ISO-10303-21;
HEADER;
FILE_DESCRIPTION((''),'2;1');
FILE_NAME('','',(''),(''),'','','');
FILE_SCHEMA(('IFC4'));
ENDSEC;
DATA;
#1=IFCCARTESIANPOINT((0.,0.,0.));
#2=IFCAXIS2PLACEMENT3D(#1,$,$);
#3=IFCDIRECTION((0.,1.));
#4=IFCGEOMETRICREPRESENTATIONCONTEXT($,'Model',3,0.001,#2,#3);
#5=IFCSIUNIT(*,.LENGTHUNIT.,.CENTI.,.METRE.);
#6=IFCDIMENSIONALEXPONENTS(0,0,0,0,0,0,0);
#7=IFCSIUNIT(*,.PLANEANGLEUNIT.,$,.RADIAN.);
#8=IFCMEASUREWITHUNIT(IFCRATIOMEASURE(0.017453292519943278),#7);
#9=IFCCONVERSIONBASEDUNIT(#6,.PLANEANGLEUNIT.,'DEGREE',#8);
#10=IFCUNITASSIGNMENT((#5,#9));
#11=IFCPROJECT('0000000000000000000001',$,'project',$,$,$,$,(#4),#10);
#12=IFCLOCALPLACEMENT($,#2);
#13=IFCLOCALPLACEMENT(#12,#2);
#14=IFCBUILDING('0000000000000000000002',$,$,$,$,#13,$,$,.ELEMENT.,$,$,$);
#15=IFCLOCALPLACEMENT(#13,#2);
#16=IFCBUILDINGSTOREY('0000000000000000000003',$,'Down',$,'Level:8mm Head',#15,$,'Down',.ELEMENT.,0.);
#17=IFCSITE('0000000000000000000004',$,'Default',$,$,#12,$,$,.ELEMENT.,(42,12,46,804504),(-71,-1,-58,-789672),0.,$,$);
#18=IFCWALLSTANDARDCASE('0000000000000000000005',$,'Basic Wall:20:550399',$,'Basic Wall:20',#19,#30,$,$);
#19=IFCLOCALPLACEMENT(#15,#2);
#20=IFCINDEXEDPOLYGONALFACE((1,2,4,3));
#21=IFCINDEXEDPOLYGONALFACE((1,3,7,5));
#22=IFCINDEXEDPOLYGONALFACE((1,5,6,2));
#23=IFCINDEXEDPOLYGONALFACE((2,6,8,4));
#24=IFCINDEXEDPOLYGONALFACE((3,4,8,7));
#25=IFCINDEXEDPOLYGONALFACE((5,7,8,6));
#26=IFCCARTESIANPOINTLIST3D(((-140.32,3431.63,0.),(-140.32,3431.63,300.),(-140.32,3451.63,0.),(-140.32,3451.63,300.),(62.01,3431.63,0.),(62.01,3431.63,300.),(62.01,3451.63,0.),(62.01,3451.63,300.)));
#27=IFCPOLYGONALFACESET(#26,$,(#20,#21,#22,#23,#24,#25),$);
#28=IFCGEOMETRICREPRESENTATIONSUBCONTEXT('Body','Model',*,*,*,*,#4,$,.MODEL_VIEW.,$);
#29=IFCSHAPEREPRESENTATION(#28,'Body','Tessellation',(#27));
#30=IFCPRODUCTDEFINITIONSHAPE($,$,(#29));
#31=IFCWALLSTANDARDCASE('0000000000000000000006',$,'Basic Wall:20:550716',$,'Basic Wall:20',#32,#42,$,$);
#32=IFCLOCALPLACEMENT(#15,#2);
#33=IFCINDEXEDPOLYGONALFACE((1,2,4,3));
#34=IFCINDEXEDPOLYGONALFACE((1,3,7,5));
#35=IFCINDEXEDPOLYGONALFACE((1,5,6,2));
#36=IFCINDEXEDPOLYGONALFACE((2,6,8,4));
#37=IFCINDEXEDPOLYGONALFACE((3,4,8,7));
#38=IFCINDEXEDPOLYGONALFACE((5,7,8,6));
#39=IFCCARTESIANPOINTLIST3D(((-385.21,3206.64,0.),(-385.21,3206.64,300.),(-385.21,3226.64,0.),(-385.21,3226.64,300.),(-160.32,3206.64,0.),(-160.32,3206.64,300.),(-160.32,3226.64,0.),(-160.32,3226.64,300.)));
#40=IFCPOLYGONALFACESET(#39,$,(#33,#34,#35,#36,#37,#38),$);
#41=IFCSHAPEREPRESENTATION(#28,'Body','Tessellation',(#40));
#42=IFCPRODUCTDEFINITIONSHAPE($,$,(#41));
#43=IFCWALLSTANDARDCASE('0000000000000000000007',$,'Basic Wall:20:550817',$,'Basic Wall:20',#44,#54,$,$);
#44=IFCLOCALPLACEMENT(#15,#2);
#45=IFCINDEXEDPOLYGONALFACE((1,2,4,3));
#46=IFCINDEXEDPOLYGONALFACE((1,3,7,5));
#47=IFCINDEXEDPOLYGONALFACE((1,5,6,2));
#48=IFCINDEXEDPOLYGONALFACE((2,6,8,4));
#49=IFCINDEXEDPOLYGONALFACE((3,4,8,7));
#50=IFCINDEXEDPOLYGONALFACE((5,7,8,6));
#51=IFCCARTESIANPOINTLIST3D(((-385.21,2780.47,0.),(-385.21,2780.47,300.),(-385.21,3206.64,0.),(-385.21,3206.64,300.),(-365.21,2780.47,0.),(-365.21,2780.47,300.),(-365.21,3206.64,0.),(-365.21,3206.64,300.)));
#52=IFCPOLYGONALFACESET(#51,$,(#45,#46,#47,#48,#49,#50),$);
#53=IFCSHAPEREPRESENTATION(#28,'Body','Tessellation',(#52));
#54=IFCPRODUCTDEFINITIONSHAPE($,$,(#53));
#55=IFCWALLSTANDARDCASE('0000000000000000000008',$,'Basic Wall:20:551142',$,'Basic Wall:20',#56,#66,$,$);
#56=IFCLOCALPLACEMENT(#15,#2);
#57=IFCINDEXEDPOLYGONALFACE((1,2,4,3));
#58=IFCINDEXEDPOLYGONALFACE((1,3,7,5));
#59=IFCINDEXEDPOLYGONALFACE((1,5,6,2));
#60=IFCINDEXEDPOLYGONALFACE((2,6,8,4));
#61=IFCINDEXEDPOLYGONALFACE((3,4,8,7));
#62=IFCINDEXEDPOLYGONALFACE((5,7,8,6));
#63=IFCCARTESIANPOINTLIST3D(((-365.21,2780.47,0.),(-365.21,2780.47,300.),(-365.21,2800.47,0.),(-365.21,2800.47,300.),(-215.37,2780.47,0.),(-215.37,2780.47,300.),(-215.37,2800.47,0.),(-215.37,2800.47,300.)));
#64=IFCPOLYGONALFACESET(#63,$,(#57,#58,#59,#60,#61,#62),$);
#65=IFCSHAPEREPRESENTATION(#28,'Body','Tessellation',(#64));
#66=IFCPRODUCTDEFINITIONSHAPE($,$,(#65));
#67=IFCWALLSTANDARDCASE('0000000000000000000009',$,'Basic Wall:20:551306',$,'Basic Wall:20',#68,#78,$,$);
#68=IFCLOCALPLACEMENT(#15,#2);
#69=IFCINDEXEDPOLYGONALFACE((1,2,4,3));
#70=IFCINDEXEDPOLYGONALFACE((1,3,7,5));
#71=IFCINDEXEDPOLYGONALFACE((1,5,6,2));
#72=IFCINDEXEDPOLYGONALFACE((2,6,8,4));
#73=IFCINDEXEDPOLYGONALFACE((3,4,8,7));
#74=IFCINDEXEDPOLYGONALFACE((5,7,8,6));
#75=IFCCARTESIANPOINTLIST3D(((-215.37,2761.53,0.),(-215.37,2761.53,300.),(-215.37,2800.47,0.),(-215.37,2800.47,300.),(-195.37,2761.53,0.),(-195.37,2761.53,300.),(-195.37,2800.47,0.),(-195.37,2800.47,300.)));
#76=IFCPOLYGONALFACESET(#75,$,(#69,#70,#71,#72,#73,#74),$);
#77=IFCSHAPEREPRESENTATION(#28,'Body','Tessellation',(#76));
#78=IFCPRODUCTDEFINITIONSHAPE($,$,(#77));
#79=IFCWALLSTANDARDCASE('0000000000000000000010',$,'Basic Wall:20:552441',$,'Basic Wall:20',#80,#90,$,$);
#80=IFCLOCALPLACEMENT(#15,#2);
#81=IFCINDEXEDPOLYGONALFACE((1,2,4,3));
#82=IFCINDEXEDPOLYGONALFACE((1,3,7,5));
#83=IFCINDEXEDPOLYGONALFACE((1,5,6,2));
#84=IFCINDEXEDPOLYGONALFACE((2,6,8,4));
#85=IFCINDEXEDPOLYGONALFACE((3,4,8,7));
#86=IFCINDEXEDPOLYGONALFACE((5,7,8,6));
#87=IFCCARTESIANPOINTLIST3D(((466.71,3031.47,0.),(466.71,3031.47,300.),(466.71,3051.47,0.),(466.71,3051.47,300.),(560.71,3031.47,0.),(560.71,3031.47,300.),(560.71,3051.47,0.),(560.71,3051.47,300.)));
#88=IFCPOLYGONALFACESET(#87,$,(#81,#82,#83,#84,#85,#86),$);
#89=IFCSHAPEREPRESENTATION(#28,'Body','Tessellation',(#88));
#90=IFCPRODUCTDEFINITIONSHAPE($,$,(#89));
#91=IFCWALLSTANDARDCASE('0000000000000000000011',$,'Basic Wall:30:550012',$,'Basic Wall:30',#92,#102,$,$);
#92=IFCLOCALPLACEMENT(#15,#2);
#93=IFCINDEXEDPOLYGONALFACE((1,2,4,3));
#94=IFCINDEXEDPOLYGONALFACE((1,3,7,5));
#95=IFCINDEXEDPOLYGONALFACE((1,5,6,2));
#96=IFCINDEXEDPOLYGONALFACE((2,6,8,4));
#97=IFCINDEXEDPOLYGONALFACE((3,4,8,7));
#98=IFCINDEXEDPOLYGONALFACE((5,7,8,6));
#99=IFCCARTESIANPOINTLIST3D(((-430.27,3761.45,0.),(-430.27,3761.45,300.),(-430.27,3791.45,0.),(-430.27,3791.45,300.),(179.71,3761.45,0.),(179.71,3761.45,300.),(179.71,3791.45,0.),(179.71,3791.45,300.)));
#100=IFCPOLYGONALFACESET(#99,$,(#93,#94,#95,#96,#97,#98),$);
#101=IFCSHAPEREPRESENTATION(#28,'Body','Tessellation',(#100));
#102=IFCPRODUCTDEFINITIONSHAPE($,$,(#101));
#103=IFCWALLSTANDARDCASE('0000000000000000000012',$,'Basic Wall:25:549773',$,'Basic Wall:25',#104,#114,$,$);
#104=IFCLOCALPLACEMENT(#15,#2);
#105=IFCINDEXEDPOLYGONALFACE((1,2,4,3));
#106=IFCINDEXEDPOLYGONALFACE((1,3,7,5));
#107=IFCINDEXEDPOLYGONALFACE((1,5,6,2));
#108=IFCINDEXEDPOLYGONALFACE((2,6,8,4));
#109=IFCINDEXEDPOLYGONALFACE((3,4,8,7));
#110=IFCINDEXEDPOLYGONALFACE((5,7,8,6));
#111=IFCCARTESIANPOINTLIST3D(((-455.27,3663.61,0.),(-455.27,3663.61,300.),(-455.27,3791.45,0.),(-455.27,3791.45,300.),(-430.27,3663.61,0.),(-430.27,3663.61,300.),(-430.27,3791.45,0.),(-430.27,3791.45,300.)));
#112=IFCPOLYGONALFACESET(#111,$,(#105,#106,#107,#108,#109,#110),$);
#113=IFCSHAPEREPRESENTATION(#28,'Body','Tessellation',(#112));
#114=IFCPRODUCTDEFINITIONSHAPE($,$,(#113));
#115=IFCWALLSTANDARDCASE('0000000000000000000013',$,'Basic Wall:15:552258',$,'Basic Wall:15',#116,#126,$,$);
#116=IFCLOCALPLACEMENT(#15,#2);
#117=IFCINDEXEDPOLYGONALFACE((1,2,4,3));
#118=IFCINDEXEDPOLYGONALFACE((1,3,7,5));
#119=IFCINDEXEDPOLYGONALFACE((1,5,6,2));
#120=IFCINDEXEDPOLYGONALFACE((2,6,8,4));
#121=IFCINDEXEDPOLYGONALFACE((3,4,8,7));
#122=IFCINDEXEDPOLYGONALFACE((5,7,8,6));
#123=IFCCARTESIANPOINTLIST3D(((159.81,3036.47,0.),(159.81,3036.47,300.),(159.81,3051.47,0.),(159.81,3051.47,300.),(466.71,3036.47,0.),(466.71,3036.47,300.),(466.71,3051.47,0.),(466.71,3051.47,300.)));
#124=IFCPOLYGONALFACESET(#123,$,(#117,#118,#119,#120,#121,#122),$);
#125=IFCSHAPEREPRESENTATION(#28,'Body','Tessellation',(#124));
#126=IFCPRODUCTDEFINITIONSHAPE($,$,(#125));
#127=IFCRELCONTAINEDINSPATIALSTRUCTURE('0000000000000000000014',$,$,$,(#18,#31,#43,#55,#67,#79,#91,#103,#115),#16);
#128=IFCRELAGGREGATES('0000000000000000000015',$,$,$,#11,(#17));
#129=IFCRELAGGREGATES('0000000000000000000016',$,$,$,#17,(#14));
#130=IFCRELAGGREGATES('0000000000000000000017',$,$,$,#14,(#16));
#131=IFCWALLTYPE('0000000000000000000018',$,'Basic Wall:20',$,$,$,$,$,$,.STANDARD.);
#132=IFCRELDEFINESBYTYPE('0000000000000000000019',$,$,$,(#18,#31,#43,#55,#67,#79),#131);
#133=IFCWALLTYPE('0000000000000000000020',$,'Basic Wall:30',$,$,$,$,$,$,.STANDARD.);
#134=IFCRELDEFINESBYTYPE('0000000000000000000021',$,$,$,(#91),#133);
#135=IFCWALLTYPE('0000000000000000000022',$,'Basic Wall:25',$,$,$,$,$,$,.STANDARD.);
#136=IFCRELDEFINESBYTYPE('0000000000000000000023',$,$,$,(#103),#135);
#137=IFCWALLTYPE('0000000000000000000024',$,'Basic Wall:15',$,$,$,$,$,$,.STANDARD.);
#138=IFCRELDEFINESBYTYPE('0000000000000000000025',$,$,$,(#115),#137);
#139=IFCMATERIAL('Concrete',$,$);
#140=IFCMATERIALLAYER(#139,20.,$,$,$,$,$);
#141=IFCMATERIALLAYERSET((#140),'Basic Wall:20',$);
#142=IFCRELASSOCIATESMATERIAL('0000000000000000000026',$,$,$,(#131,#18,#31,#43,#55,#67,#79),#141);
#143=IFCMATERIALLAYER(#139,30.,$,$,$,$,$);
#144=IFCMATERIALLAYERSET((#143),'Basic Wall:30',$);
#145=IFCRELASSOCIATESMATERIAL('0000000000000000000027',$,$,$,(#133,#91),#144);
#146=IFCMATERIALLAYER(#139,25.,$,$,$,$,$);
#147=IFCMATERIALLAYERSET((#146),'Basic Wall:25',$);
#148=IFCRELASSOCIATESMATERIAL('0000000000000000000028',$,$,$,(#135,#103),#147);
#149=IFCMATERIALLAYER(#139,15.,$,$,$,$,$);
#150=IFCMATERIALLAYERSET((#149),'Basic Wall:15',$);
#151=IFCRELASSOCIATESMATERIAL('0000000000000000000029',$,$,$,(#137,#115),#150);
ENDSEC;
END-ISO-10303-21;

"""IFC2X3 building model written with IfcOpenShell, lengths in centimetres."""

from ifc_helpers import new_model, entity, si_unit, converted_unit, direction, frame, frame_2d, origin, place, context, subcontext, project, spatial, rectangle, extrude, material, layer, layer_set, layer_usage, type_object, element, save


model = new_model("IFC2X3")

# Units and contexts
model_context = context("Model", 3, precision=0.001, world=origin(), true_north=direction((0.0, 1.0)))
body_context = subcontext(model_context, "Body", "Model", "MODEL_VIEW")
ifc_project = project(units=[si_unit("LENGTHUNIT", "METRE", prefix="CENTI"), converted_unit("PLANEANGLEUNIT", "DEGREE", entity("IfcRatioMeasure", 0.017453292519943278), si_unit("PLANEANGLEUNIT", "RADIAN"), dimensions=[0, 0, 0, 0, 0, 0, 0])], contexts=[model_context])

# Site, building, storey
site_placement = place(None, origin())
site = spatial("IfcSite", under=ifc_project, at=site_placement, Name="Default", CompositionType="ELEMENT", RefLatitude=(42, 12, 46, 804504), RefLongitude=(-71, -1, -58, -789672), RefElevation=0.0)
building_placement = place(site_placement, origin())
building = spatial("IfcBuilding", under=site, at=building_placement, CompositionType="ELEMENT")
storey_placement = place(building_placement, origin())
storey = spatial("IfcBuildingStorey", under=building, at=storey_placement, Name="Down", ObjectType="Level:8mm Head", LongName="Down", CompositionType="ELEMENT", Elevation=0.0)

# Walls
ifc_material = material(Name="Concrete")
ifc_layer_1 = layer(ifc_material, 20.0)
ifc_layer_set_1 = layer_set([ifc_layer_1], Name="Basic Wall:20")
wall_type_1 = type_object("IfcWallType", Name="Basic Wall:20", PredefinedType="STANDARD", material=ifc_layer_set_1)
ifc_layer_usage_1 = layer_usage(ifc_layer_set_1, "AXIS2", "NEGATIVE", 10.0)
wall_1_placement = place(storey_placement, frame((62.01, 3441.63, 0.0), z_axis=(0.0, 0.0, 1.0), x_axis=(-1.0, 0.0, 0.0)))
element("IfcWallStandardCase", 1, at=wall_1_placement, inside=storey, type_object=wall_type_1, material=ifc_layer_usage_1, Name="Basic Wall:20:550399", ObjectType="Basic Wall:20", context=body_context, shape_type="SweptSolid", body=[
    extrude(rectangle(XDim=202.33, YDim=20.0, at=frame_2d((101.17, 0.0), x_axis=(-1.0, 0.0))), origin(), (0.0, 0.0, 1.0), 300.0),
])
ifc_layer_usage_2 = layer_usage(ifc_layer_set_1, "AXIS2", "NEGATIVE", 10.0)
wall_2_placement = place(storey_placement, frame((-160.32, 3216.64, 0.0), z_axis=(0.0, 0.0, 1.0), x_axis=(-1.0, 0.0, 0.0)))
element("IfcWallStandardCase", 2, at=wall_2_placement, inside=storey, type_object=wall_type_1, material=ifc_layer_usage_2, Name="Basic Wall:20:550716", ObjectType="Basic Wall:20", context=body_context, shape_type="SweptSolid", body=[
    extrude(rectangle(XDim=224.89, YDim=20.0, at=frame_2d((112.44, 0.0), x_axis=(-1.0, 0.0))), origin(), (0.0, 0.0, 1.0), 300.0),
])
ifc_layer_usage_3 = layer_usage(ifc_layer_set_1, "AXIS2", "POSITIVE", -10.0)
wall_3_placement = place(storey_placement, frame((-375.21, 3206.64, 0.0), z_axis=(0.0, 0.0, 1.0), x_axis=(0.0, -1.0, 0.0)))
element("IfcWallStandardCase", 3, at=wall_3_placement, inside=storey, type_object=wall_type_1, material=ifc_layer_usage_3, Name="Basic Wall:20:550817", ObjectType="Basic Wall:20", context=body_context, shape_type="SweptSolid", body=[
    extrude(rectangle(XDim=426.17, YDim=20.0, at=frame_2d((213.09, 0.0), x_axis=(-1.0, 0.0))), origin(), (0.0, 0.0, 1.0), 300.0),
])
ifc_layer_usage_4 = layer_usage(ifc_layer_set_1, "AXIS2", "POSITIVE", -10.0)
wall_4_placement = place(storey_placement, frame((-365.21, 2790.47, 0.0)))
element("IfcWallStandardCase", 4, at=wall_4_placement, inside=storey, type_object=wall_type_1, material=ifc_layer_usage_4, Name="Basic Wall:20:551142", ObjectType="Basic Wall:20", context=body_context, shape_type="SweptSolid", body=[
    extrude(rectangle(XDim=149.84, YDim=20.0, at=frame_2d((74.92, 0.0), x_axis=(-1.0, 0.0))), origin(), (0.0, 0.0, 1.0), 300.0),
])
ifc_layer_usage_5 = layer_usage(ifc_layer_set_1, "AXIS2", "NEGATIVE", 10.0)
wall_5_placement = place(storey_placement, frame((-205.37, 2800.47, 0.0), z_axis=(0.0, 0.0, 1.0), x_axis=(0.0, -1.0, 0.0)))
element("IfcWallStandardCase", 5, at=wall_5_placement, inside=storey, type_object=wall_type_1, material=ifc_layer_usage_5, Name="Basic Wall:20:551306", ObjectType="Basic Wall:20", context=body_context, shape_type="SweptSolid", body=[
    extrude(rectangle(XDim=38.94, YDim=20.0, at=frame_2d((19.47, 0.0), x_axis=(-1.0, 0.0))), origin(), (0.0, 0.0, 1.0), 300.0),
])
ifc_layer_usage_6 = layer_usage(ifc_layer_set_1, "AXIS2", "NEGATIVE", 10.0)
wall_6_placement = place(storey_placement, frame((466.71, 3041.47, 0.0)))
element("IfcWallStandardCase", 6, at=wall_6_placement, inside=storey, type_object=wall_type_1, material=ifc_layer_usage_6, Name="Basic Wall:20:552441", ObjectType="Basic Wall:20", context=body_context, shape_type="SweptSolid", body=[
    extrude(rectangle(XDim=94.0, YDim=20.0, at=frame_2d((47.0, 0.0), x_axis=(-1.0, 0.0))), origin(), (0.0, 0.0, 1.0), 300.0),
])
ifc_layer_2 = layer(ifc_material, 30.0)
ifc_layer_set_2 = layer_set([ifc_layer_2], Name="Basic Wall:30")
ifc_layer_usage_7 = layer_usage(ifc_layer_set_2, "AXIS2", "NEGATIVE", 15.0)
wall_type_2 = type_object("IfcWallType", Name="Basic Wall:30", PredefinedType="STANDARD", material=ifc_layer_set_2)
wall_7_placement = place(storey_placement, frame((-430.27, 3776.45, 0.0)))
element("IfcWallStandardCase", 7, at=wall_7_placement, inside=storey, type_object=wall_type_2, material=ifc_layer_usage_7, Name="Basic Wall:30:550012", ObjectType="Basic Wall:30", context=body_context, shape_type="SweptSolid", body=[
    extrude(rectangle(XDim=609.98, YDim=30.0, at=frame_2d((304.99, 0.0), x_axis=(-1.0, 0.0))), origin(), (0.0, 0.0, 1.0), 300.0),
])
ifc_layer_3 = layer(ifc_material, 25.0)
ifc_layer_set_3 = layer_set([ifc_layer_3], Name="Basic Wall:25")
ifc_layer_usage_8 = layer_usage(ifc_layer_set_3, "AXIS2", "NEGATIVE", 12.5)
wall_type_3 = type_object("IfcWallType", Name="Basic Wall:25", PredefinedType="STANDARD", material=ifc_layer_set_3)
wall_8_placement = place(storey_placement, frame((-442.77, 3663.61, 0.0), z_axis=(0.0, 0.0, 1.0), x_axis=(0.0, 1.0, 0.0)))
element("IfcWallStandardCase", 8, at=wall_8_placement, inside=storey, type_object=wall_type_3, material=ifc_layer_usage_8, Name="Basic Wall:25:549773", ObjectType="Basic Wall:25", context=body_context, shape_type="SweptSolid", body=[
    extrude(rectangle(XDim=127.84, YDim=25.0, at=frame_2d((63.92, 0.0), x_axis=(-1.0, 0.0))), origin(), (0.0, 0.0, 1.0), 300.0),
])
ifc_layer_4 = layer(ifc_material, 15.0)
ifc_layer_set_4 = layer_set([ifc_layer_4], Name="Basic Wall:15")
ifc_layer_usage_9 = layer_usage(ifc_layer_set_4, "AXIS2", "POSITIVE", -7.5)
wall_type_4 = type_object("IfcWallType", Name="Basic Wall:15", PredefinedType="STANDARD", material=ifc_layer_set_4)
wall_9_placement = place(storey_placement, frame((159.81, 3043.97, 0.0)))
element("IfcWallStandardCase", 9, at=wall_9_placement, inside=storey, type_object=wall_type_4, material=ifc_layer_usage_9, Name="Basic Wall:15:552258", ObjectType="Basic Wall:15", context=body_context, shape_type="SweptSolid", body=[
    extrude(rectangle(XDim=306.91, YDim=15.0, at=frame_2d((153.45, 0.0), x_axis=(-1.0, 0.0))), origin(), (0.0, 0.0, 1.0), 300.0),
])

save(model, "model.ifc")
